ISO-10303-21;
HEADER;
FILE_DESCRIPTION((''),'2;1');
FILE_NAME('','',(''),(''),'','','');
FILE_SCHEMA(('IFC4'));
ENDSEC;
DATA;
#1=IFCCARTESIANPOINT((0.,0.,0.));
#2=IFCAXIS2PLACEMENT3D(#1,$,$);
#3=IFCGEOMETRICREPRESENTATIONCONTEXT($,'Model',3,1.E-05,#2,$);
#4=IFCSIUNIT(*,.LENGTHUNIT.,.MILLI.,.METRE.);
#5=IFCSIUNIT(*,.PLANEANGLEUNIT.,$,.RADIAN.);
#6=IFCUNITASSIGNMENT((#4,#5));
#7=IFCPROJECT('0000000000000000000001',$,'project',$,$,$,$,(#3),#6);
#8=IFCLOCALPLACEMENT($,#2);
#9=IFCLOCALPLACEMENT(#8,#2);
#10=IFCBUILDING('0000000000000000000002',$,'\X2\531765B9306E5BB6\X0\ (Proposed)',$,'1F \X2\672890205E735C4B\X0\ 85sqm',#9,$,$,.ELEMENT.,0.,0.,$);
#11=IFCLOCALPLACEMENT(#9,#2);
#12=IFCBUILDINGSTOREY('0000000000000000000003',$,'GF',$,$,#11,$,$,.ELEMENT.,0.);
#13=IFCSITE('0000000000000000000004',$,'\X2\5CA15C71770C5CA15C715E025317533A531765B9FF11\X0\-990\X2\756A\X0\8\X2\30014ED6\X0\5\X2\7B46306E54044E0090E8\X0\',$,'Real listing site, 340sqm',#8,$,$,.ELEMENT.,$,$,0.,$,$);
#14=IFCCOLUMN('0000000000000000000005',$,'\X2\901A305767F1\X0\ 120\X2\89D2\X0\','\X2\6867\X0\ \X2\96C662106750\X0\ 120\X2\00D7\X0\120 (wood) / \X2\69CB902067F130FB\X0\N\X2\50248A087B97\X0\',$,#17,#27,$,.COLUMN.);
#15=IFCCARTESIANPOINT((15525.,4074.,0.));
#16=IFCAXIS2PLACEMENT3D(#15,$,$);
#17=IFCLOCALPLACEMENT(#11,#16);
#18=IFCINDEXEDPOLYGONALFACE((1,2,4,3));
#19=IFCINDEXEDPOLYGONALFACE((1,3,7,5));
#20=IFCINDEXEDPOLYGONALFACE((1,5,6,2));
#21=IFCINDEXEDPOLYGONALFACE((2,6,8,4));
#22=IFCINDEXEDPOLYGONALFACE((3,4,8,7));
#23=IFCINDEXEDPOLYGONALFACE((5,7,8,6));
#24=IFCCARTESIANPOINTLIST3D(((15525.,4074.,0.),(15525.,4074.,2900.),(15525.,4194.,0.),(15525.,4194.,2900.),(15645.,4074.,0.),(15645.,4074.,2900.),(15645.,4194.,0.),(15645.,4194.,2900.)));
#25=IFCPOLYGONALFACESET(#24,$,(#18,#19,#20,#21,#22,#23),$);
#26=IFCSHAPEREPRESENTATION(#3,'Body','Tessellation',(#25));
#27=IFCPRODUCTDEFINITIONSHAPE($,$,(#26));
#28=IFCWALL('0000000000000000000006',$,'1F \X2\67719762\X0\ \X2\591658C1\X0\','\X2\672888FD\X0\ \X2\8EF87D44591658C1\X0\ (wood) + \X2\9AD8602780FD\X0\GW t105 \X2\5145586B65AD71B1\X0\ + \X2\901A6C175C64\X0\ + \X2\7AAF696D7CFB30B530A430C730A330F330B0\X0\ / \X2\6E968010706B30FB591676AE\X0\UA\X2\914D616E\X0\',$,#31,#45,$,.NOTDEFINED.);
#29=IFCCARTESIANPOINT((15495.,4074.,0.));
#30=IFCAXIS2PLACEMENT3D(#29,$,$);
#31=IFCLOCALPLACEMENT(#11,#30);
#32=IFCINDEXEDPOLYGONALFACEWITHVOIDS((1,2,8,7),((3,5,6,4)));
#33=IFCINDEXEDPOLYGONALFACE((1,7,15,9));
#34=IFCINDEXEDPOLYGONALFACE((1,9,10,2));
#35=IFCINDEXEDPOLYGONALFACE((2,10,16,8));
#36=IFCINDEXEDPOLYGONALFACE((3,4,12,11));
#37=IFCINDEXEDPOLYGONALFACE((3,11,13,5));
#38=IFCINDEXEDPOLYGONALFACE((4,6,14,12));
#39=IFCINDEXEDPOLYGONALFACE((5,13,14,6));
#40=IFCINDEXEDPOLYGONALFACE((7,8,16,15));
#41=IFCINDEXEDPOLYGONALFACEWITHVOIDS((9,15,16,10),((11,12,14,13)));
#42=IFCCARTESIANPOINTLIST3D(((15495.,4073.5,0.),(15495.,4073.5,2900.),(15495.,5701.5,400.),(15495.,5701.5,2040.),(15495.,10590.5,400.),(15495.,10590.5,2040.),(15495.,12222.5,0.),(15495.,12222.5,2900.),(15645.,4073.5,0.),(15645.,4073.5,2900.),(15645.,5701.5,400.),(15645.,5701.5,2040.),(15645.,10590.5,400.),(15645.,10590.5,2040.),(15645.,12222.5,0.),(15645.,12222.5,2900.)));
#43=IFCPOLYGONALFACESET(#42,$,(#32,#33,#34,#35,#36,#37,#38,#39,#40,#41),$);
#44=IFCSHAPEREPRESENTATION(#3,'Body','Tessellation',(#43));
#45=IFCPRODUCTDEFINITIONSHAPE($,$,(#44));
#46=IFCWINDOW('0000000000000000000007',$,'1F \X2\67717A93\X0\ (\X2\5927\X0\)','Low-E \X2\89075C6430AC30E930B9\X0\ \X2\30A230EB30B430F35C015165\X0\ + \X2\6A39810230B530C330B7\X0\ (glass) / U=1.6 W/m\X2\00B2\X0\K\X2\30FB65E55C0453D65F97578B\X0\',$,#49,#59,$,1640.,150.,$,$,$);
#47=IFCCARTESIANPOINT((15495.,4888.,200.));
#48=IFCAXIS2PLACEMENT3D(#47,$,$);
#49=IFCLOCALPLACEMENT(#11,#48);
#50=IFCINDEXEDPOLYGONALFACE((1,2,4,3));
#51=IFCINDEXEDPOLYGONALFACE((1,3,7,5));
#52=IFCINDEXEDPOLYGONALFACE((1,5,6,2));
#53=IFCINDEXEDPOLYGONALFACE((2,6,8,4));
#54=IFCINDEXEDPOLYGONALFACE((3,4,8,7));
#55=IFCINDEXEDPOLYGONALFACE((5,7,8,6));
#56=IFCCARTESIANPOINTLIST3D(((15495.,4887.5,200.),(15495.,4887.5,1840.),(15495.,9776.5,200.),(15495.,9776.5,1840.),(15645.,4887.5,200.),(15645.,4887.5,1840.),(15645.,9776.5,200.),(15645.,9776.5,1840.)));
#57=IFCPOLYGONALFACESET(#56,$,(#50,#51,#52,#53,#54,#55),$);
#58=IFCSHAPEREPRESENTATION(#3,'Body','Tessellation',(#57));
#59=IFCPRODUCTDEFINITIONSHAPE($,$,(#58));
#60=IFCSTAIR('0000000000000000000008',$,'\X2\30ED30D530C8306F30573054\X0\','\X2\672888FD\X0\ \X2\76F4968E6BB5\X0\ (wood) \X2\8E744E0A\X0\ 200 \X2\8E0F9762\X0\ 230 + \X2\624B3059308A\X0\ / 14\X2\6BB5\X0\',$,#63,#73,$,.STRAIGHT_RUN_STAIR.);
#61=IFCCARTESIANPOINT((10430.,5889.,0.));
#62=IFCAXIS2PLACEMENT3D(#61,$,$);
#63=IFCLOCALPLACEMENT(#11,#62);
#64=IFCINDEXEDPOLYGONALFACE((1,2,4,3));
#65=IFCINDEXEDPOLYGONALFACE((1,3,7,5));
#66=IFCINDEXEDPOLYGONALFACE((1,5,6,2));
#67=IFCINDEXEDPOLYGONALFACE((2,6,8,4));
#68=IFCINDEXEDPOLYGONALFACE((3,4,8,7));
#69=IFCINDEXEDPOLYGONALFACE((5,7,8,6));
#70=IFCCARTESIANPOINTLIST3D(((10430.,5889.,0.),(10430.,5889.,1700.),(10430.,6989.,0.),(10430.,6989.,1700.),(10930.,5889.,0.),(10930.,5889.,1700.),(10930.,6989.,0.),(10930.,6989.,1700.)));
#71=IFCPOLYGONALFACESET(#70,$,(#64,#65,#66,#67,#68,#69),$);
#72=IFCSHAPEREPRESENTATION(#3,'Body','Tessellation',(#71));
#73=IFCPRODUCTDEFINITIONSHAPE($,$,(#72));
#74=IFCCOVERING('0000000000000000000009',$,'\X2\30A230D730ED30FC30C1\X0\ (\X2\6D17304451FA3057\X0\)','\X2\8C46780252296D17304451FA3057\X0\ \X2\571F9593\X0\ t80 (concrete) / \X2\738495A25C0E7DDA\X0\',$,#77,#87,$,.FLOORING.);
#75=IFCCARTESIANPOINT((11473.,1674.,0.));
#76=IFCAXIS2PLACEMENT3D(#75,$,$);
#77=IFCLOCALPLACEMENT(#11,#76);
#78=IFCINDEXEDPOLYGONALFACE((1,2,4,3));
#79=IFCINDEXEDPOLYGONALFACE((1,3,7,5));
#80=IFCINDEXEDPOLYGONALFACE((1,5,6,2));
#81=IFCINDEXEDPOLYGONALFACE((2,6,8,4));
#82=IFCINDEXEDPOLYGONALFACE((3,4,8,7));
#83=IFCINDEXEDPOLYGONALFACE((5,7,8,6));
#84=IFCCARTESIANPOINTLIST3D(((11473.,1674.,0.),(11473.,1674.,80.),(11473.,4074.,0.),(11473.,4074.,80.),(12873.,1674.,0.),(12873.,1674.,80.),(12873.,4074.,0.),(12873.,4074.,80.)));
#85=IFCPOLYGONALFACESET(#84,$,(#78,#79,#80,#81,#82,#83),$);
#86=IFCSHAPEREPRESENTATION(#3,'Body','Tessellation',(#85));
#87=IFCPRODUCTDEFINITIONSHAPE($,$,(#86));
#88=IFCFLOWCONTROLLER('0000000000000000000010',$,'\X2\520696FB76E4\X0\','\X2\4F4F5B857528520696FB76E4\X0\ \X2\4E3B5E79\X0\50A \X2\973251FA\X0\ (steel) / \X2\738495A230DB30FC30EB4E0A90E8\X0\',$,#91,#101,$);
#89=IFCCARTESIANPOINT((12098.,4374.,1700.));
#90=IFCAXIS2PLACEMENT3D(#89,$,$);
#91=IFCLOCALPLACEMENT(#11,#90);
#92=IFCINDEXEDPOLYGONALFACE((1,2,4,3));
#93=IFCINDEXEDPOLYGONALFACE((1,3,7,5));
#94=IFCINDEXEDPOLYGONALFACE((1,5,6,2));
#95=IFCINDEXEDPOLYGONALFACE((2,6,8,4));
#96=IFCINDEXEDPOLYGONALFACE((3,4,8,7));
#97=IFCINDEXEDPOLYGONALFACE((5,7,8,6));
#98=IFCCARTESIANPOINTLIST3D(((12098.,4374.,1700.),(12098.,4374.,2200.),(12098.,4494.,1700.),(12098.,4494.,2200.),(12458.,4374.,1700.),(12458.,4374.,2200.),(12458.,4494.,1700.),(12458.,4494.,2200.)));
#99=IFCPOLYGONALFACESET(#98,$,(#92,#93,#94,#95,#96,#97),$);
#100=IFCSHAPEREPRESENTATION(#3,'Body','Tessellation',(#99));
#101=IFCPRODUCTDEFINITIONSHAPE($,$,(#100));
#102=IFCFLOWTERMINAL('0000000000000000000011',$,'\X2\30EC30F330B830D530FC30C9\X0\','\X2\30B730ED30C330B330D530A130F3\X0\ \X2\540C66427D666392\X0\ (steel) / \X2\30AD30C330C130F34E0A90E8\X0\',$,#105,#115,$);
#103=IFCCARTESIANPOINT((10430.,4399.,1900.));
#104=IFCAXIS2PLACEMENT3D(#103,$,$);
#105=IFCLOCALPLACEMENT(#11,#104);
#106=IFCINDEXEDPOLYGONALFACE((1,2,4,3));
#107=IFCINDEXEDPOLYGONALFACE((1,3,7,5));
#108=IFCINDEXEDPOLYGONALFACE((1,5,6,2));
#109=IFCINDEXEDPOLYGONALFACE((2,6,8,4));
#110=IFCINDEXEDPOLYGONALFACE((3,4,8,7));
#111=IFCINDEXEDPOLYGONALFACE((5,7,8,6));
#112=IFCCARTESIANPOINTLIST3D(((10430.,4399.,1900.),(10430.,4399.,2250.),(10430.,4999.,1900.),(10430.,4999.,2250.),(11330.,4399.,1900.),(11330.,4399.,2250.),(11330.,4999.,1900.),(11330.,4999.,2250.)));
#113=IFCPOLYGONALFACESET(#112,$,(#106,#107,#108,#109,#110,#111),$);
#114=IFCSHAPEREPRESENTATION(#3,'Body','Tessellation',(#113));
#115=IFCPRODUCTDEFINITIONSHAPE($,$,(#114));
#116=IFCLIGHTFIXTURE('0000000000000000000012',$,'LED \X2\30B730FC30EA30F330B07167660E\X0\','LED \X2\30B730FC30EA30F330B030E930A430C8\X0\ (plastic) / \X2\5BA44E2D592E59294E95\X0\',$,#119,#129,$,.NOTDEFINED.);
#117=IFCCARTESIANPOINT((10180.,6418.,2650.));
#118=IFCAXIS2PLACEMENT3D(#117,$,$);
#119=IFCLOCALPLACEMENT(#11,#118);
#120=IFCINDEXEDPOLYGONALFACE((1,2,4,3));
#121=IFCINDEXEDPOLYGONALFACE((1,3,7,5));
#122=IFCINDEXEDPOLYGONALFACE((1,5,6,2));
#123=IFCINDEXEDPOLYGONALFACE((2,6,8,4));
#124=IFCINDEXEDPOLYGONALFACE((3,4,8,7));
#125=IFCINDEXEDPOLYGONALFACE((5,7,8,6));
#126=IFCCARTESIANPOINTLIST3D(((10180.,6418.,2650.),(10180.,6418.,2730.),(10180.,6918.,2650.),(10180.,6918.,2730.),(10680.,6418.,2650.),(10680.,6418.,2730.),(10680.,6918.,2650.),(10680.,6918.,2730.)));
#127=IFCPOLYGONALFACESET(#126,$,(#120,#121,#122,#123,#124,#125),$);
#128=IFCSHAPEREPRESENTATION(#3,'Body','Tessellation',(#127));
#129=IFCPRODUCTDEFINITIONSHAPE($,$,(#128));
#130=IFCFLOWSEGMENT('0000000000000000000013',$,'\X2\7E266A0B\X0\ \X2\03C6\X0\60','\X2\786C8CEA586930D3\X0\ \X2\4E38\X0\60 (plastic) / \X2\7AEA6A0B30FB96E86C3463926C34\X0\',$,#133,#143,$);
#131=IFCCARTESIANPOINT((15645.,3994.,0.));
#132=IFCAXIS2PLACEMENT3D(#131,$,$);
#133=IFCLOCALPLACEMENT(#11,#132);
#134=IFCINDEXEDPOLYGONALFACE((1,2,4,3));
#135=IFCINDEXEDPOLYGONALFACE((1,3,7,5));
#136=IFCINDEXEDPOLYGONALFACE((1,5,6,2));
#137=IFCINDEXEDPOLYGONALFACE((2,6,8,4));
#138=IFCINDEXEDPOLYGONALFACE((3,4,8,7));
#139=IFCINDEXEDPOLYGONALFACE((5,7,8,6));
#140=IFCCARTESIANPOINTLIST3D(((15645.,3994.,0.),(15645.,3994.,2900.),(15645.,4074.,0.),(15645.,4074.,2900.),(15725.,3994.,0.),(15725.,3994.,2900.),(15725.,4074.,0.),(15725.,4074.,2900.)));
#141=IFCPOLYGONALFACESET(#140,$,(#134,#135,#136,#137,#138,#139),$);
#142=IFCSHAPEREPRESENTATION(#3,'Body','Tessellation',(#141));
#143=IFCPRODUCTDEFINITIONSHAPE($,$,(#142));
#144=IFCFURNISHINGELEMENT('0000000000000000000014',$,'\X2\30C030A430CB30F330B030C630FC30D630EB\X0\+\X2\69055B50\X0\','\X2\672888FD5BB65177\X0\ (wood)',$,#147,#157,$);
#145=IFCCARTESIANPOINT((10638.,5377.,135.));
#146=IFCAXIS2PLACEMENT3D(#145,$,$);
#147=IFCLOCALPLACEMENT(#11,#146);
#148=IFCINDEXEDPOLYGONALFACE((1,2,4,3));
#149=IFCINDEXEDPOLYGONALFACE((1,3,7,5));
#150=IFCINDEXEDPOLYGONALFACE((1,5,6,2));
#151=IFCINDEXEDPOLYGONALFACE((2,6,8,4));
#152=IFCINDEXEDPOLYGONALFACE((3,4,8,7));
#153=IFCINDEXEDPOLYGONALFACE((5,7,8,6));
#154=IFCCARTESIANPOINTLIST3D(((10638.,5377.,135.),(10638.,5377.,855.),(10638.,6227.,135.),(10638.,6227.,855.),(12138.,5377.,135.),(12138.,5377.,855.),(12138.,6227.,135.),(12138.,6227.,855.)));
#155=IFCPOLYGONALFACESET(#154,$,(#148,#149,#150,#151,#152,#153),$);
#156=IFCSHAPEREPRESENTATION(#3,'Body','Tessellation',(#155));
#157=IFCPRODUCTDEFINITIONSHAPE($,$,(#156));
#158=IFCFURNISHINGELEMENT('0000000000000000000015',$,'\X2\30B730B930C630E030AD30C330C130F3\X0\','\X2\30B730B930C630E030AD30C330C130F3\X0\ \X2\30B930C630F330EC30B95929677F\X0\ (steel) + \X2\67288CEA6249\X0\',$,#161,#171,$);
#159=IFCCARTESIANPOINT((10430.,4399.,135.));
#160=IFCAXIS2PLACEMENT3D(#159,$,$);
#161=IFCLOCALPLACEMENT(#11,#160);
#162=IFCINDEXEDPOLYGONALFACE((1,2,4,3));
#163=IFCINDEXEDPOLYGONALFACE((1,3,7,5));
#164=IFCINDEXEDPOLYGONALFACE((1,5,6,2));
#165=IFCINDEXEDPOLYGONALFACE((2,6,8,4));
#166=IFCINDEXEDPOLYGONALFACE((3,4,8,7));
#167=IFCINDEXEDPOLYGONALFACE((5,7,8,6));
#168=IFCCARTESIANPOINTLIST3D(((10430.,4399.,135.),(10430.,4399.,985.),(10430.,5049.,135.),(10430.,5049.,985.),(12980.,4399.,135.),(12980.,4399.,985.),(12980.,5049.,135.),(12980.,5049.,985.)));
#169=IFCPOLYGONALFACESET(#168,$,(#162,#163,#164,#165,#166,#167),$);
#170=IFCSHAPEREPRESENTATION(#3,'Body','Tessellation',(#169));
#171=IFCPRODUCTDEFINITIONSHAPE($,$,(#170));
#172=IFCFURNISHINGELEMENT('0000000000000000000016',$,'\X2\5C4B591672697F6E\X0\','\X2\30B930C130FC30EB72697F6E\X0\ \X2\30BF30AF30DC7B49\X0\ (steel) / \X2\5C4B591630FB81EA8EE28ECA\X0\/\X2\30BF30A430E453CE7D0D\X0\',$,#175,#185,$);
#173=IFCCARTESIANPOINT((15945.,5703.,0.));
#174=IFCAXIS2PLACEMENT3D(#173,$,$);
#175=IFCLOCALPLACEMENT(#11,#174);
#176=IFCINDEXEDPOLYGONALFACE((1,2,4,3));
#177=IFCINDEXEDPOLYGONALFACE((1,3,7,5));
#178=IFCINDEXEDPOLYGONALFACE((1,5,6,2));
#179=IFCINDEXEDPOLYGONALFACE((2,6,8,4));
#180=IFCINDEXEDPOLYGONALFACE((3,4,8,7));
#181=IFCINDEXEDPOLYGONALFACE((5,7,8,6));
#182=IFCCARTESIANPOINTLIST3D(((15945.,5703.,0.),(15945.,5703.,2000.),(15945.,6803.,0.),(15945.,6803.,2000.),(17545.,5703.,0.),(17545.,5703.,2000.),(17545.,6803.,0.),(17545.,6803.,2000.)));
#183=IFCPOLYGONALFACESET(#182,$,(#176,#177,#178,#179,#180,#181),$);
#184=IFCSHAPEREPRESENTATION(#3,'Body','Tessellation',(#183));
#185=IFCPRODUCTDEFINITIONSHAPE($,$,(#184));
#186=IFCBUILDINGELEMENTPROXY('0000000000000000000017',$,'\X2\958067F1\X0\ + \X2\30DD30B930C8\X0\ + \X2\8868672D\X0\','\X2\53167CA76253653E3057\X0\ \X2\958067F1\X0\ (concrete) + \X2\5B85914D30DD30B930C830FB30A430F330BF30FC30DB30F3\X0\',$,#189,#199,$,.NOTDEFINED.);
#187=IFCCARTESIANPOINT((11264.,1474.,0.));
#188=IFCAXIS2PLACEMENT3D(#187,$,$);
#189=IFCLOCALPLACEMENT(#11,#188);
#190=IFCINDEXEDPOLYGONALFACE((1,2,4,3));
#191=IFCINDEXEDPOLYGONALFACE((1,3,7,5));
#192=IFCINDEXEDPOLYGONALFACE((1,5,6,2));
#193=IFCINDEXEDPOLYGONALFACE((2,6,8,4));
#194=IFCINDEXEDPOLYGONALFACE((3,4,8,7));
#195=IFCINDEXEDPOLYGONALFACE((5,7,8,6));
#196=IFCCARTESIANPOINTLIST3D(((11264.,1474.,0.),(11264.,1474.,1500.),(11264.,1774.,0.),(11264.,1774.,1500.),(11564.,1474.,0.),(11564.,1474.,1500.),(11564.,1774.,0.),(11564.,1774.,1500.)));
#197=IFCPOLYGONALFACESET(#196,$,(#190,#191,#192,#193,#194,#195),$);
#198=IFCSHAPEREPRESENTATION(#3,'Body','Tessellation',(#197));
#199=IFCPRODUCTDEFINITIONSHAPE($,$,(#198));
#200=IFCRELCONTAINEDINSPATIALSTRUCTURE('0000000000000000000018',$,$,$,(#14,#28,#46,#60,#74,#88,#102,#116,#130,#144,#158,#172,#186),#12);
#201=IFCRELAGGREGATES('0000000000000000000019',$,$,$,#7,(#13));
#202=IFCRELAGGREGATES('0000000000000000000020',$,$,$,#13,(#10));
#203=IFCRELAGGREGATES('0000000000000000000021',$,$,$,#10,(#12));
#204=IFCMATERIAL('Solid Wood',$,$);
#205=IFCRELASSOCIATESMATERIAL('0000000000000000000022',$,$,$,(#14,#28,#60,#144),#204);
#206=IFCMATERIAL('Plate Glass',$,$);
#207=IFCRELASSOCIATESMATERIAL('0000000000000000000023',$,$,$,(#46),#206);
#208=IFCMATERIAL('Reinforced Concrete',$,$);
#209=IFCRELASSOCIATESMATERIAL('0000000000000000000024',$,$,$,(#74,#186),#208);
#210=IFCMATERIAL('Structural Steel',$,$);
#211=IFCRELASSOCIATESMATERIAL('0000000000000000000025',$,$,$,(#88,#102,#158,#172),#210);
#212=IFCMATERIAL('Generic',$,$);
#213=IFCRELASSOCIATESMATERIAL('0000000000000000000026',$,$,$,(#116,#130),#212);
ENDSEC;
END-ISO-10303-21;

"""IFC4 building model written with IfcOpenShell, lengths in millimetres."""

from ifc_helpers import new_model, si_unit, frame, frame_2d, origin, place, context, project, spatial, rectangle, extrude, material, element, fill, save


model = new_model("IFC4")

# Units and contexts
model_context = context("Model", 3, precision=1e-05, world=origin())
ifc_project = project(units=[si_unit("LENGTHUNIT", "METRE", prefix="MILLI"), si_unit("PLANEANGLEUNIT", "RADIAN")], contexts=[model_context])

# Site, building, storey
site_placement = place(None, origin())
site = spatial("IfcSite", under=ifc_project, at=site_placement, Name="岡山県岡山市北区北方１-990番8、他5筆の各一部", ObjectType="Real listing site, 340sqm", CompositionType="ELEMENT", RefElevation=0.0)
building_placement = place(site_placement, origin())
building = spatial("IfcBuilding", under=site, at=building_placement, Name="北方の家 (Proposed)", ObjectType="1F 木造平屋 85sqm", CompositionType="ELEMENT", ElevationOfRefHeight=0.0, ElevationOfTerrain=0.0)
storey_placement = place(building_placement, origin())
storey = spatial("IfcBuildingStorey", under=building, at=storey_placement, Name="GF", CompositionType="ELEMENT", Elevation=0.0)

# Column
ifc_material_1 = material(Name="Solid Wood")
column_1_placement = place(storey_placement, frame((15525.0, 4074.0, 0.0)))
element("IfcColumn", 1, at=column_1_placement, inside=storey, material=ifc_material_1, Name="通し柱 120角", Description="桧 集成材 120×120 (wood) / 構造柱・N値計算", PredefinedType="COLUMN", context=model_context, shape_type="SweptSolid", body=[
    extrude(rectangle(XDim=120.0, YDim=120.0, at=frame_2d((60.0, 60.0))), frame((15525.0, 4074.0, 0.0)), (0.0, 0.0, 1.0), 2900.0),
])

# Wall, opening, window
wall_1_placement = place(storey_placement, frame((15495.0, 4074.0, 0.0)))
wall_1 = element("IfcWall", 2, at=wall_1_placement, inside=storey, material=ifc_material_1, Name="1F 東面 外壁", Description="木製 軸組外壁 (wood) + 高性能GW t105 充填断熱 + 通気層 + 窯業系サイディング / 準耐火・外皮UA配慮", PredefinedType="NOTDEFINED", context=model_context, shape_type="SweptSolid", body=[
    extrude(rectangle(XDim=150.0, YDim=8149.0, at=frame_2d((75.0, 4074.0))), frame((15495.0, 4074.0, 0.0)), (0.0, 0.0, 1.0), 2900.0),
])
opening_placement = place(storey_placement, frame((15495.0, 4888.0, 200.0)))
opening = element("IfcOpeningElement", 3, at=opening_placement, cuts=wall_1, PredefinedType="NOTDEFINED", context=model_context, shape_type="SweptSolid", body=[
    extrude(rectangle(XDim=150.0, YDim=4889.0, at=frame_2d((75.0, 2444.0))), frame((15495.0, 4888.0, 200.0)), (0.0, 0.0, 1.0), 1640.0),
])
ifc_material_2 = material(Name="Plate Glass")
window_placement = place(storey_placement, frame((15495.0, 4888.0, 200.0)))
window = element("IfcWindow", 4, at=window_placement, inside=storey, material=ifc_material_2, Name="1F 東窓 (大)", Description="Low-E 複層ガラス アルゴン封入 + 樹脂サッシ (glass) / U=1.6 W/m²K・日射取得型", OverallHeight=1640.0, OverallWidth=150.0, context=model_context, shape_type="SweptSolid", body=[
    extrude(rectangle(XDim=150.0, YDim=4889.0, at=frame_2d((75.0, 2444.0))), frame((15495.0, 4888.0, 200.0)), (0.0, 0.0, 1.0), 1640.0),
])
fill(opening, window)

# Stair
stair_placement = place(storey_placement, frame((10430.0, 5889.0, 0.0)))
element("IfcStair", 5, at=stair_placement, inside=storey, material=ifc_material_1, Name="ロフトはしご", Description="木製 直階段 (wood) 蹴上 200 踏面 230 + 手すり / 14段", PredefinedType="STRAIGHT_RUN_STAIR", context=model_context, shape_type="SweptSolid", body=[
    extrude(rectangle(XDim=500.0, YDim=1100.0, at=frame_2d((250.0, 550.0))), frame((10430.0, 5889.0, 0.0)), (0.0, 0.0, 1.0), 1700.0),
])

# Covering
ifc_material_3 = material(Name="Reinforced Concrete")
covering_placement = place(storey_placement, frame((11473.0, 1674.0, 0.0)))
element("IfcCovering", 6, at=covering_placement, inside=storey, material=ifc_material_3, Name="アプローチ (洗い出し)", Description="豆砂利洗い出し 土間 t80 (concrete) / 玄関導線", PredefinedType="FLOORING", context=model_context, shape_type="SweptSolid", body=[
    extrude(rectangle(XDim=1400.0, YDim=2400.0, at=frame_2d((700.0, 1200.0))), frame((11473.0, 1674.0, 0.0)), (0.0, 0.0, 1.0), 80.0),
])

# Flow controller
ifc_material_4 = material(Name="Structural Steel")
flow_controller_placement = place(storey_placement, frame((12098.0, 4374.0, 1700.0)))
element("IfcFlowController", 7, at=flow_controller_placement, inside=storey, material=ifc_material_4, Name="分電盤", Description="住宅用分電盤 主幹50A 露出 (steel) / 玄関ホール上部", context=model_context, shape_type="SweptSolid", body=[
    extrude(rectangle(XDim=360.0, YDim=120.0, at=frame_2d((180.0, 60.0))), frame((12098.0, 4374.0, 1700.0)), (0.0, 0.0, 1.0), 500.0),
])

# Flow terminal
flow_terminal_placement = place(storey_placement, frame((10430.0, 4399.0, 1900.0)))
element("IfcFlowTerminal", 8, at=flow_terminal_placement, inside=storey, material=ifc_material_4, Name="レンジフード", Description="シロッコファン 同時給排 (steel) / キッチン上部", context=model_context, shape_type="SweptSolid", body=[
    extrude(rectangle(XDim=900.0, YDim=600.0, at=frame_2d((450.0, 300.0))), frame((10430.0, 4399.0, 1900.0)), (0.0, 0.0, 1.0), 350.0),
])

# Light fixture
ifc_material_5 = material(Name="Generic")
light_fixture_placement = place(storey_placement, frame((10180.0, 6418.0, 2650.0)))
element("IfcLightFixture", 9, at=light_fixture_placement, inside=storey, material=ifc_material_5, Name="LED シーリング照明", Description="LED シーリングライト (plastic) / 室中央天井", PredefinedType="NOTDEFINED", context=model_context, shape_type="SweptSolid", body=[
    extrude(rectangle(XDim=500.0, YDim=500.0, at=frame_2d((250.0, 250.0))), frame((10180.0, 6418.0, 2650.0)), (0.0, 0.0, 1.0), 80.0),
])

# Flow segment
flow_segment_placement = place(storey_placement, frame((15645.0, 3994.0, 0.0)))
element("IfcFlowSegment", 10, at=flow_segment_placement, inside=storey, material=ifc_material_5, Name="縦樋 φ60", Description="硬質塩ビ 丸60 (plastic) / 竪樋・雨水排水", context=model_context, shape_type="SweptSolid", body=[
    extrude(rectangle(XDim=80.0, YDim=80.0, at=frame_2d((40.0, 40.0))), frame((15645.0, 3994.0, 0.0)), (0.0, 0.0, 1.0), 2900.0),
])

# Furnishing elements
furnishing_1_placement = place(storey_placement, frame((10638.0, 5377.0, 135.0)))
element("IfcFurnishingElement", 11, at=furnishing_1_placement, inside=storey, material=ifc_material_1, Name="ダイニングテーブル+椅子", Description="木製家具 (wood)", context=model_context, shape_type="SweptSolid", body=[
    extrude(rectangle(XDim=1500.0, YDim=850.0, at=frame_2d((750.0, 425.0))), frame((10638.0, 5377.0, 135.0)), (0.0, 0.0, 1.0), 720.0),
])
furnishing_2_placement = place(storey_placement, frame((10430.0, 4399.0, 135.0)))
element("IfcFurnishingElement", 12, at=furnishing_2_placement, inside=storey, material=ifc_material_4, Name="システムキッチン", Description="システムキッチン ステンレス天板 (steel) + 木質扉", context=model_context, shape_type="SweptSolid", body=[
    extrude(rectangle(XDim=2550.0, YDim=650.0, at=frame_2d((1275.0, 325.0))), frame((10430.0, 4399.0, 135.0)), (0.0, 0.0, 1.0), 850.0),
])
furnishing_3_placement = place(storey_placement, frame((15945.0, 5703.0, 0.0)))
element("IfcFurnishingElement", 13, at=furnishing_3_placement, inside=storey, material=ifc_material_4, Name="屋外物置", Description="スチール物置 タクボ等 (steel) / 屋外・自転車/タイヤ収納", context=model_context, shape_type="SweptSolid", body=[
    extrude(rectangle(XDim=1600.0, YDim=1100.0, at=frame_2d((800.0, 550.0))), frame((15945.0, 5703.0, 0.0)), (0.0, 0.0, 1.0), 2000.0),
])

# Building element proxy
proxy_placement = place(storey_placement, frame((11264.0, 1474.0, 0.0)))
element("IfcBuildingElementProxy", 14, at=proxy_placement, inside=storey, material=ifc_material_3, Name="門柱 + ポスト + 表札", Description="化粧打放し 門柱 (concrete) + 宅配ポスト・インターホン", PredefinedType="NOTDEFINED", context=model_context, shape_type="SweptSolid", body=[
    extrude(rectangle(XDim=300.0, YDim=300.0, at=frame_2d((150.0, 150.0))), frame((11264.0, 1474.0, 0.0)), (0.0, 0.0, 1.0), 1500.0),
])

save(model, "model.ifc")
